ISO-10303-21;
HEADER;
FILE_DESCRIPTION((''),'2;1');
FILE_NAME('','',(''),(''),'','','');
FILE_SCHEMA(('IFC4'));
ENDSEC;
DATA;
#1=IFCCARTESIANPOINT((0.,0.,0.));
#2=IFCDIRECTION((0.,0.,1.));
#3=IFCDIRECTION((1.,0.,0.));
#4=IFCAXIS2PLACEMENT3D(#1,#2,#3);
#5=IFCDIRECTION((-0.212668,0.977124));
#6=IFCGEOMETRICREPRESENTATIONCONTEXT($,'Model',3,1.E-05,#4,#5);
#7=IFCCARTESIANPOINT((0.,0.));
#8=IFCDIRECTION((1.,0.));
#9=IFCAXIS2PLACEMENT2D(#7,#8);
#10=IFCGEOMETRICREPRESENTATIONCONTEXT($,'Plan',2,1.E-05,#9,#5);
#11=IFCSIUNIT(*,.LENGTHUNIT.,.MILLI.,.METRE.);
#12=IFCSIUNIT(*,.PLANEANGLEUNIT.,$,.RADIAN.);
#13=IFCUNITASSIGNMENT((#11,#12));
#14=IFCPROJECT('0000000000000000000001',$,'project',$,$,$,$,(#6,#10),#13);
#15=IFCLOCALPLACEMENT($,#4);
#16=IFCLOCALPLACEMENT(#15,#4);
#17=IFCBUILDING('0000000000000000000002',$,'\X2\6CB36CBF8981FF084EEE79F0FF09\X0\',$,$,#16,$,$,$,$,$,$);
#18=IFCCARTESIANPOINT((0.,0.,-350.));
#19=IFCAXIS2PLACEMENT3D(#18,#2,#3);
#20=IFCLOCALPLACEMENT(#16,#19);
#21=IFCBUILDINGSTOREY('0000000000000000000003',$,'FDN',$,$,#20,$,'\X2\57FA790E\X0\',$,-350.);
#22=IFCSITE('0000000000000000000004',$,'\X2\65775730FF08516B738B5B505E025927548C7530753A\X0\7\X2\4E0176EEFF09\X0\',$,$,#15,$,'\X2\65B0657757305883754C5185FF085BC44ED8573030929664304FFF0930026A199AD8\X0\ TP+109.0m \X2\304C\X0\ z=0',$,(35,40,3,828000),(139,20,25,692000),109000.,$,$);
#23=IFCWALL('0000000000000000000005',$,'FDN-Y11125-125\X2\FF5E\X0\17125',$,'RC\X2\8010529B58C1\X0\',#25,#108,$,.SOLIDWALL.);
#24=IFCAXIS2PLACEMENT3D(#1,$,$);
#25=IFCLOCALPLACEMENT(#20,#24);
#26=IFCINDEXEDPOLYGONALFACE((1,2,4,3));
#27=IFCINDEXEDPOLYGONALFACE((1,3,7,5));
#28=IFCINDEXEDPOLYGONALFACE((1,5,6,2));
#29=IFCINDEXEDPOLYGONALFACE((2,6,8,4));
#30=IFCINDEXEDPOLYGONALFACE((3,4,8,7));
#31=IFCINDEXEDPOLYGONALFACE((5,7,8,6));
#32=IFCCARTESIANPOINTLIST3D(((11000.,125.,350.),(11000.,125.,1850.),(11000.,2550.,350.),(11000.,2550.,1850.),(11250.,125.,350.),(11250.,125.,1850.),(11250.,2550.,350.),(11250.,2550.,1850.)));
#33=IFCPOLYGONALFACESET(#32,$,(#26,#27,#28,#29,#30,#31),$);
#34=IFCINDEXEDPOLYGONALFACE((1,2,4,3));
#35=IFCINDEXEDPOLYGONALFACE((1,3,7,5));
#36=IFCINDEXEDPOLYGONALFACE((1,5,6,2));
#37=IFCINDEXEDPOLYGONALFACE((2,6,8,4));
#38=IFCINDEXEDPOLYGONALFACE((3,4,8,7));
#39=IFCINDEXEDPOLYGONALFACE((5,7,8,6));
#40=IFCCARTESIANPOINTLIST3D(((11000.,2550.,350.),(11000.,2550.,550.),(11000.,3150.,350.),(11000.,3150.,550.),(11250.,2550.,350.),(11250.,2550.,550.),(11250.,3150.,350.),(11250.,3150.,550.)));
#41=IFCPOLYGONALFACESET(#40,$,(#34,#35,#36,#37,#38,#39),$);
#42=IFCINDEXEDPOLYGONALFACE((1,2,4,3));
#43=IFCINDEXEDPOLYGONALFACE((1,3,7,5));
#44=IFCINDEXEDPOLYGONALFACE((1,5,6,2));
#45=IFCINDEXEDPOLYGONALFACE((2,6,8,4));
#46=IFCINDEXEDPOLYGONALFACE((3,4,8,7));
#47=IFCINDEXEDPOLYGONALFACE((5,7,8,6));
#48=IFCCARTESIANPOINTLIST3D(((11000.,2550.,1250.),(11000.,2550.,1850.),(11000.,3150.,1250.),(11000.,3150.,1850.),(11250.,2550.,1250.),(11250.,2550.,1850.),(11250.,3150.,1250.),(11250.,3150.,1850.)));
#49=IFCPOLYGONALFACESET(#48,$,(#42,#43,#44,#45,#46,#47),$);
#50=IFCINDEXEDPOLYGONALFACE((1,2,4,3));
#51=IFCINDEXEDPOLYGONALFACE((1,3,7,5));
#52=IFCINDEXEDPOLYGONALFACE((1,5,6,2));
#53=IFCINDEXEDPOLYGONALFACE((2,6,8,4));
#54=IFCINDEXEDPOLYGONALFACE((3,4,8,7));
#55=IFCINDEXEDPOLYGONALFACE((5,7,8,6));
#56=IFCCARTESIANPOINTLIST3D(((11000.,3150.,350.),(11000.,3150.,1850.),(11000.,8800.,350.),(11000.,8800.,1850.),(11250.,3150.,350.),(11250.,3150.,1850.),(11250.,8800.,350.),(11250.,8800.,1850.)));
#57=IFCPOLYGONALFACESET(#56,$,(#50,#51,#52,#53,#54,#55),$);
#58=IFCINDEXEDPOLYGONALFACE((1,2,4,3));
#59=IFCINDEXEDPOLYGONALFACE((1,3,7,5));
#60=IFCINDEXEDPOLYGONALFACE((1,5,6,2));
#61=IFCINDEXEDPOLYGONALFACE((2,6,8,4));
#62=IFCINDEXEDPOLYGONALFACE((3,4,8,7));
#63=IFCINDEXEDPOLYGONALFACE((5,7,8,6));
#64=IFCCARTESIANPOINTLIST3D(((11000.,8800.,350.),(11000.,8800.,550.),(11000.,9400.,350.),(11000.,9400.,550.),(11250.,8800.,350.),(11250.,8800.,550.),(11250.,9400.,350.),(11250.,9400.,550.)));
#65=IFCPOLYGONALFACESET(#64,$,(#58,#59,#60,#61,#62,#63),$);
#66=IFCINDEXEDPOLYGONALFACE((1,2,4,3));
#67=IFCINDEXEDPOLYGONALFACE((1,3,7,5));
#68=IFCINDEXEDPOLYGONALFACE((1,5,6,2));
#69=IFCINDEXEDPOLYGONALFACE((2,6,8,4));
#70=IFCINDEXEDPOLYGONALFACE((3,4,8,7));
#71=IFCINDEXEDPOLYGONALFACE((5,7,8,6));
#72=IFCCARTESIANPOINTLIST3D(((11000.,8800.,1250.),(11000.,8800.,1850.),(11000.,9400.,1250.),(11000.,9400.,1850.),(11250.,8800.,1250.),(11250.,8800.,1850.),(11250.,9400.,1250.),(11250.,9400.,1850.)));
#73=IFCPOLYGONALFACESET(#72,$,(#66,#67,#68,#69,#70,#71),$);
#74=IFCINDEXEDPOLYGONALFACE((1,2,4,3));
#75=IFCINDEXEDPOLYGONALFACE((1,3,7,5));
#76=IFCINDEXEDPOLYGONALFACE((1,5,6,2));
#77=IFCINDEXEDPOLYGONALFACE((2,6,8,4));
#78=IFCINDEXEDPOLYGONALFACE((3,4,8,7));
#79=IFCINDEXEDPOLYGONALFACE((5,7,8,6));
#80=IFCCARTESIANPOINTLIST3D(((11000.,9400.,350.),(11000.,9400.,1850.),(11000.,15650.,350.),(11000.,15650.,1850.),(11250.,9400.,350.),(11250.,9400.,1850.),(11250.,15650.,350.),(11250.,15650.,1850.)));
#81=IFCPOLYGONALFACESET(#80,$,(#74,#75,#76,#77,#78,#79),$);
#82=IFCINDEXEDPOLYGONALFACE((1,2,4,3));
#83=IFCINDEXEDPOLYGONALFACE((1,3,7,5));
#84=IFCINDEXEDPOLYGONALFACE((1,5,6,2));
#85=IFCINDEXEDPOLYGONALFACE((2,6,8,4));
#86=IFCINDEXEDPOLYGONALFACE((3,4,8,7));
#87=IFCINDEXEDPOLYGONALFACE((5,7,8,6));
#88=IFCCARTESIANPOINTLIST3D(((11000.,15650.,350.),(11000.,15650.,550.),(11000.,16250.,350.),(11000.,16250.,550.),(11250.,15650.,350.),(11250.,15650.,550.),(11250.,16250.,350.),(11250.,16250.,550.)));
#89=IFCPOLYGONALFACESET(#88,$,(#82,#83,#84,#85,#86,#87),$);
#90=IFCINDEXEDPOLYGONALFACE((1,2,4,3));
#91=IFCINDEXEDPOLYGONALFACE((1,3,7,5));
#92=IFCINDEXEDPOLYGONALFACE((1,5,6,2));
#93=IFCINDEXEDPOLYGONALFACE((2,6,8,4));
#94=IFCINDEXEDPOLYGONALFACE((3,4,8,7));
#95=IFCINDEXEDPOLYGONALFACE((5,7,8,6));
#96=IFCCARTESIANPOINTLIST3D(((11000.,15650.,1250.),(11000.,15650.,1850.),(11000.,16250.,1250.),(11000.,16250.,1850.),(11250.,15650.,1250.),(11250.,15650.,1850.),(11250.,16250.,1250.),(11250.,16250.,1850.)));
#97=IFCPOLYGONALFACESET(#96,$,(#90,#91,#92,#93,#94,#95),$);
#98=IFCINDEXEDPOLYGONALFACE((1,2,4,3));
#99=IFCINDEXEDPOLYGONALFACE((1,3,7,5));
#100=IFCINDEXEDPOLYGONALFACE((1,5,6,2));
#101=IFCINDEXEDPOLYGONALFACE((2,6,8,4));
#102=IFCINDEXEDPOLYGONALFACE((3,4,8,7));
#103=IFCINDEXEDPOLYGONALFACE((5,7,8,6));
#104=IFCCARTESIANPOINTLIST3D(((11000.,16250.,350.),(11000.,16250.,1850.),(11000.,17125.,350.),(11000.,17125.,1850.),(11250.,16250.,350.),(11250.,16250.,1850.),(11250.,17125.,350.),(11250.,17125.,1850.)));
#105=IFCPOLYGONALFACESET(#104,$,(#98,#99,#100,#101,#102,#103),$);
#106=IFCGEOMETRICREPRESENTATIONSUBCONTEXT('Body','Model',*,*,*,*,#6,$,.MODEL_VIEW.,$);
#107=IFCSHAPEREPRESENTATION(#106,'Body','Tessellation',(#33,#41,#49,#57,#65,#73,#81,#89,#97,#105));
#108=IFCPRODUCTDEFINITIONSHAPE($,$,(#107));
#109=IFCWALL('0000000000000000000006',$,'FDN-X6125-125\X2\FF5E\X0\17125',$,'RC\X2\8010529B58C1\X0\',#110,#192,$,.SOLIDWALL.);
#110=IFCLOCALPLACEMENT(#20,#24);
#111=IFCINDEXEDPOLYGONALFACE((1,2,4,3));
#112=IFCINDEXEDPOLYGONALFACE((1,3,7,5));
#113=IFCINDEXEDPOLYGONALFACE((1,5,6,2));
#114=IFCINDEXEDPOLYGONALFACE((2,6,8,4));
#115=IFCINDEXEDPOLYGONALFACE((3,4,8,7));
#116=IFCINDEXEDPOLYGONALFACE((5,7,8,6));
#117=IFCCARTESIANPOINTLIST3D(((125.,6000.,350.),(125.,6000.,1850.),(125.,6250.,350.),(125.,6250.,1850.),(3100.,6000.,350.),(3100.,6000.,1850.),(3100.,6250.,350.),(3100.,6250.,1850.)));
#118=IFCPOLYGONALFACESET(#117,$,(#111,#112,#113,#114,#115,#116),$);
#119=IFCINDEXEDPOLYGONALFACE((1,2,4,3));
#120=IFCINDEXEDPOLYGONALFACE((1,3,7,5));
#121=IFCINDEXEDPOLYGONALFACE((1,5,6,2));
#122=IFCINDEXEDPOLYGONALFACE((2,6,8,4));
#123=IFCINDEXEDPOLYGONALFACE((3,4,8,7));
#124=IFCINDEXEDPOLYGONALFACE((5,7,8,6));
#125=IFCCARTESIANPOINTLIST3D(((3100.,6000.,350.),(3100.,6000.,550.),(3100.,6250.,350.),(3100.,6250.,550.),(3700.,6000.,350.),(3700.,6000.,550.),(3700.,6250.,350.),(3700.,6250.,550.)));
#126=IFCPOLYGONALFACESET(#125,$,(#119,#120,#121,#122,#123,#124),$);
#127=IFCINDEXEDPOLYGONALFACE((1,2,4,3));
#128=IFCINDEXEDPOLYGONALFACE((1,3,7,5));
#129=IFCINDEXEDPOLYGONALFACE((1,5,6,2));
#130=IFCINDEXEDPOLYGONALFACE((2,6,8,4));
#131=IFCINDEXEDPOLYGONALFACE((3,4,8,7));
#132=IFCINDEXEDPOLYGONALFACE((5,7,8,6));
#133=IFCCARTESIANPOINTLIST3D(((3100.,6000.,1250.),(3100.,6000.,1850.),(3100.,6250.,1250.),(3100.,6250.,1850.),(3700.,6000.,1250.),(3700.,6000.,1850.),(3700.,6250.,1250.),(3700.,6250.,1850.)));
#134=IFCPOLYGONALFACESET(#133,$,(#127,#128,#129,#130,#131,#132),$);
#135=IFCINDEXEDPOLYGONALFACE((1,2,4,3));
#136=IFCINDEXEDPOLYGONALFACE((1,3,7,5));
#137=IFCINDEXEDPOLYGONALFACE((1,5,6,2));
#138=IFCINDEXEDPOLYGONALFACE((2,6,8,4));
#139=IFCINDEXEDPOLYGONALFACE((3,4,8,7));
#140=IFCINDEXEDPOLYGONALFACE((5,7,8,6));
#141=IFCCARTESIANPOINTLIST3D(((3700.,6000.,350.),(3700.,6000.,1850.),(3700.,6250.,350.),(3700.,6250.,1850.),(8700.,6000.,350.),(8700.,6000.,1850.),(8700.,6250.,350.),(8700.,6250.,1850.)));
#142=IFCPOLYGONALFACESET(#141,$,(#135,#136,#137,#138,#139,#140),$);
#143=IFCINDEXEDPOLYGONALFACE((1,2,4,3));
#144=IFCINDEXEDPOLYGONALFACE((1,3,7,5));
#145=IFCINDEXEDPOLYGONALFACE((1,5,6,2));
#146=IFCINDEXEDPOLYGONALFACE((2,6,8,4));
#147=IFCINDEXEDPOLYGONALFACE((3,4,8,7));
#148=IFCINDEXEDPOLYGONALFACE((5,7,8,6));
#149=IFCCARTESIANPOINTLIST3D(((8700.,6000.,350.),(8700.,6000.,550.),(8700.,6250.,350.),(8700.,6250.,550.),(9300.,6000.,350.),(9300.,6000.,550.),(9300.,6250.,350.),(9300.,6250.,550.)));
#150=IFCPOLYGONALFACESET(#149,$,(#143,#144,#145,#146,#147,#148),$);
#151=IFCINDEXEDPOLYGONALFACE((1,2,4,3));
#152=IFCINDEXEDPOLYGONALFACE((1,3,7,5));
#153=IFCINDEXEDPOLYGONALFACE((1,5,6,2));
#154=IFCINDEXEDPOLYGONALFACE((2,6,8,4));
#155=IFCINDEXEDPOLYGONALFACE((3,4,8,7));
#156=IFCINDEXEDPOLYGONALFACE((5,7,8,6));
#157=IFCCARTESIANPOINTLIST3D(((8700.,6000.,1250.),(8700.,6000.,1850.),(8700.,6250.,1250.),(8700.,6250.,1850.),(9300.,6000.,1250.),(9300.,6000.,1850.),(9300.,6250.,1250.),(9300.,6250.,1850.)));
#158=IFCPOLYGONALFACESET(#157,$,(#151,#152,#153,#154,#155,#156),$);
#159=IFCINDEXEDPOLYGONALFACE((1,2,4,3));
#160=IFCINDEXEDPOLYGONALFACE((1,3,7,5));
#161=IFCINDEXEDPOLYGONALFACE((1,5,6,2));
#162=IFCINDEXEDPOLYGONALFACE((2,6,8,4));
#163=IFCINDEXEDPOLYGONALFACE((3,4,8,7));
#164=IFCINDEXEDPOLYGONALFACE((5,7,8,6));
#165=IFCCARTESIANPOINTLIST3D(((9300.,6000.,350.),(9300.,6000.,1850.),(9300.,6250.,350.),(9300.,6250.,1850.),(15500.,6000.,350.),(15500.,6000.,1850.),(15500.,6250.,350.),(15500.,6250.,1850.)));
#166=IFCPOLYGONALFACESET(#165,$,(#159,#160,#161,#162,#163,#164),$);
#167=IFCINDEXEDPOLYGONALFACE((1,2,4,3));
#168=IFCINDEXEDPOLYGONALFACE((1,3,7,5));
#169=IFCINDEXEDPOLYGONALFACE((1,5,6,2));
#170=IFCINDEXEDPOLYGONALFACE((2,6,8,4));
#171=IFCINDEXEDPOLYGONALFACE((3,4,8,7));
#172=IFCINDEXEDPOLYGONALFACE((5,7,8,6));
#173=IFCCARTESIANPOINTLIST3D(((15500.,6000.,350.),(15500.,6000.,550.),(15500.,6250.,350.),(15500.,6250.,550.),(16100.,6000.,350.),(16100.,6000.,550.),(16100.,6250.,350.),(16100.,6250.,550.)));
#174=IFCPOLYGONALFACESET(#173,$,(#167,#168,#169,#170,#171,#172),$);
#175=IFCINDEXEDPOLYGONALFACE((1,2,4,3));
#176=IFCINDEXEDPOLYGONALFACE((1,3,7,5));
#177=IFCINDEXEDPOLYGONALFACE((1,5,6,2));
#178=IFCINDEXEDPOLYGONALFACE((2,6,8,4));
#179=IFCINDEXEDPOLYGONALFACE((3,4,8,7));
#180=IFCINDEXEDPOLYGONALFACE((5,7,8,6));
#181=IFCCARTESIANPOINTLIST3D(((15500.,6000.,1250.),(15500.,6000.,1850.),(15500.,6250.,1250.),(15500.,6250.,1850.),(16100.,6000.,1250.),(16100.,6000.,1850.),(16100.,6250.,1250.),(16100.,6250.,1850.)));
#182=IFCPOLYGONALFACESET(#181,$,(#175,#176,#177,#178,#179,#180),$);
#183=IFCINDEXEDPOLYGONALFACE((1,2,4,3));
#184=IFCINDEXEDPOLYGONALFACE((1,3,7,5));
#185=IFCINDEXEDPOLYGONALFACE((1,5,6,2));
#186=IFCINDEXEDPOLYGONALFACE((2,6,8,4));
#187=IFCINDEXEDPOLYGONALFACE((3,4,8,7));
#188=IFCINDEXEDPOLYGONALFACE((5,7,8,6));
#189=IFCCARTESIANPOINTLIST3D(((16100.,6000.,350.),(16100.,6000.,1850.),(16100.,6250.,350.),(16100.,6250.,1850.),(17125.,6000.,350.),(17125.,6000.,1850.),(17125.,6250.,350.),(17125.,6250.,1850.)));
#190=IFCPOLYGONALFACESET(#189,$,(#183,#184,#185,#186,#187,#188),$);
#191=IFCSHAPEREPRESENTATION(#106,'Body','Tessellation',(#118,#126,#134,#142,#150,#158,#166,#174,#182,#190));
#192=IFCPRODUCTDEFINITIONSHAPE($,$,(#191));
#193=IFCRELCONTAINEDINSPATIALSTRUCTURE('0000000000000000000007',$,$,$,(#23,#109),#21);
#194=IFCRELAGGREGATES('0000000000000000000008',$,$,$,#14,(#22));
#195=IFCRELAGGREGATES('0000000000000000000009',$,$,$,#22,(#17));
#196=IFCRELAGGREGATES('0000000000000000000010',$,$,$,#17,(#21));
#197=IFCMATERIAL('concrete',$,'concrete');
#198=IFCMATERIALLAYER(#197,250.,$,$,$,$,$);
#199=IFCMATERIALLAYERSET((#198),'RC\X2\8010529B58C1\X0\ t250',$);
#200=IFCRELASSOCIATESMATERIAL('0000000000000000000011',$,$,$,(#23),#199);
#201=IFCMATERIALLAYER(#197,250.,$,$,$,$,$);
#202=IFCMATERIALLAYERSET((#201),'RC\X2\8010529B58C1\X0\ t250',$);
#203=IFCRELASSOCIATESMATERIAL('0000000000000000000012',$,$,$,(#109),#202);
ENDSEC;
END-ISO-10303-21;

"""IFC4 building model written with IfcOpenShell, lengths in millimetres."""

from ifc_helpers import new_model, si_unit, direction, frame, frame_2d, origin_with_axes, origin_2d_with_axis, place, context, subcontext, project, spatial, rectangle, extrude, material, layer, layer_set, layer_usage, element, save


model = new_model("IFC4")

# Units and contexts
model_context = context("Model", 3, precision=1e-05, world=origin_with_axes(), true_north=direction((-0.212668, 0.977124)))
plan_context = context("Plan", 2, precision=1e-05, world=origin_2d_with_axis(), true_north=direction((-0.212668, 0.977124)))
body_context = subcontext(model_context, "Body", "Model", "MODEL_VIEW")
ifc_project = project(units=[si_unit("LENGTHUNIT", "METRE", prefix="MILLI"), si_unit("PLANEANGLEUNIT", "RADIAN")], contexts=[model_context, plan_context])

# Site, building, storey
site_placement = place(None, origin_with_axes())
site = spatial("IfcSite", under=ifc_project, at=site_placement, Name="敷地（八王子市大和田町7丁目）", LongName="新敷地境界内（寄付地を除く）。標高 TP+109.0m が z=0", RefLatitude=(35, 40, 3, 828000), RefLongitude=(139, 20, 25, 692000), RefElevation=109000.0)
building_placement = place(site_placement, origin_with_axes())
building = spatial("IfcBuilding", under=site, at=building_placement, Name="河沿要（仮称）")
storey_placement = place(building_placement, frame((0.0, 0.0, -350.0), z_axis=(0.0, 0.0, 1.0), x_axis=(1.0, 0.0, 0.0)))
storey = spatial("IfcBuildingStorey", under=building, at=storey_placement, Name="FDN", LongName="基礎", Elevation=-350.0)

# Shared definitions
ifc_material_1 = material(Name="concrete", Category="concrete")

# Walls, openings
ifc_layer_1 = layer(ifc_material_1, 250.0)
ifc_layer_set_1 = layer_set([ifc_layer_1], Name="RC耐力壁 t250")
ifc_layer_usage_1 = layer_usage(ifc_layer_set_1, "AXIS2", "POSITIVE", 0.0)
wall_1_placement = place(storey_placement, origin_with_axes())
wall_1 = element("IfcWall", 1, at=wall_1_placement, inside=storey, material=ifc_layer_usage_1, Name="FDN-Y11125-125～17125", ObjectType="RC耐力壁", PredefinedType="SOLIDWALL", context=body_context, shape_type="SweptSolid", body=[
    extrude(rectangle(XDim=250.0, YDim=2425.0, at=frame_2d((11125.0, 1337.5))), frame((0.0, 0.0, 350.0)), (0.0, 0.0, 1.0), 1500.0),
    extrude(rectangle(XDim=250.0, YDim=600.0, at=frame_2d((11125.0, 2850.0))), frame((0.0, 0.0, 350.0)), (0.0, 0.0, 1.0), 200.0),
    extrude(rectangle(XDim=250.0, YDim=600.0, at=frame_2d((11125.0, 2850.0))), frame((0.0, 0.0, 1250.0)), (0.0, 0.0, 1.0), 600.0),
    extrude(rectangle(XDim=250.0, YDim=5650.0, at=frame_2d((11125.0, 5975.0))), frame((0.0, 0.0, 350.0)), (0.0, 0.0, 1.0), 1500.0),
    extrude(rectangle(XDim=250.0, YDim=600.0, at=frame_2d((11125.0, 9100.0))), frame((0.0, 0.0, 350.0)), (0.0, 0.0, 1.0), 200.0),
    extrude(rectangle(XDim=250.0, YDim=600.0, at=frame_2d((11125.0, 9100.0))), frame((0.0, 0.0, 1250.0)), (0.0, 0.0, 1.0), 600.0),
    extrude(rectangle(XDim=250.0, YDim=6250.0, at=frame_2d((11125.0, 12525.0))), frame((0.0, 0.0, 350.0)), (0.0, 0.0, 1.0), 1500.0),
    extrude(rectangle(XDim=250.0, YDim=600.0, at=frame_2d((11125.0, 15950.0))), frame((0.0, 0.0, 350.0)), (0.0, 0.0, 1.0), 200.0),
    extrude(rectangle(XDim=250.0, YDim=600.0, at=frame_2d((11125.0, 15950.0))), frame((0.0, 0.0, 1250.0)), (0.0, 0.0, 1.0), 600.0),
    extrude(rectangle(XDim=250.0, YDim=875.0, at=frame_2d((11125.0, 16687.5))), frame((0.0, 0.0, 350.0)), (0.0, 0.0, 1.0), 1500.0),
])
opening_1_placement = place(storey_placement, origin_with_axes())
element("IfcOpeningElement", 2, at=opening_1_placement, inside=storey, cuts=wall_1, PredefinedType="OPENING", context=body_context, shape_type="SweptSolid", body=[
    extrude(rectangle(XDim=300.0, YDim=600.0, at=frame_2d((11125.0, 2850.0))), frame((0.0, 0.0, 550.0)), (0.0, 0.0, 1.0), 700.0),
])
opening_2_placement = place(storey_placement, origin_with_axes())
element("IfcOpeningElement", 3, at=opening_2_placement, inside=storey, cuts=wall_1, PredefinedType="OPENING", context=body_context, shape_type="SweptSolid", body=[
    extrude(rectangle(XDim=300.0, YDim=600.0, at=frame_2d((11125.0, 9100.0))), frame((0.0, 0.0, 550.0)), (0.0, 0.0, 1.0), 700.0),
])
opening_3_placement = place(storey_placement, origin_with_axes())
element("IfcOpeningElement", 4, at=opening_3_placement, inside=storey, cuts=wall_1, PredefinedType="OPENING", context=body_context, shape_type="SweptSolid", body=[
    extrude(rectangle(XDim=300.0, YDim=600.0, at=frame_2d((11125.0, 15950.0))), frame((0.0, 0.0, 550.0)), (0.0, 0.0, 1.0), 700.0),
])
ifc_layer_2 = layer(ifc_material_1, 250.0)
ifc_layer_set_2 = layer_set([ifc_layer_2], Name="RC耐力壁 t250")
ifc_layer_usage_2 = layer_usage(ifc_layer_set_2, "AXIS2", "POSITIVE", 0.0)
wall_2_placement = place(storey_placement, origin_with_axes())
wall_2 = element("IfcWall", 5, at=wall_2_placement, inside=storey, material=ifc_layer_usage_2, Name="FDN-X6125-125～17125", ObjectType="RC耐力壁", PredefinedType="SOLIDWALL", context=body_context, shape_type="SweptSolid", body=[
    extrude(rectangle(XDim=2975.0, YDim=250.0, at=frame_2d((1612.5, 6125.0))), frame((0.0, 0.0, 350.0)), (0.0, 0.0, 1.0), 1500.0),
    extrude(rectangle(XDim=600.0, YDim=250.0, at=frame_2d((3400.0, 6125.0))), frame((0.0, 0.0, 350.0)), (0.0, 0.0, 1.0), 200.0),
    extrude(rectangle(XDim=600.0, YDim=250.0, at=frame_2d((3400.0, 6125.0))), frame((0.0, 0.0, 1250.0)), (0.0, 0.0, 1.0), 600.0),
    extrude(rectangle(XDim=5000.0, YDim=250.0, at=frame_2d((6200.0, 6125.0))), frame((0.0, 0.0, 350.0)), (0.0, 0.0, 1.0), 1500.0),
    extrude(rectangle(XDim=600.0, YDim=250.0, at=frame_2d((9000.0, 6125.0))), frame((0.0, 0.0, 350.0)), (0.0, 0.0, 1.0), 200.0),
    extrude(rectangle(XDim=600.0, YDim=250.0, at=frame_2d((9000.0, 6125.0))), frame((0.0, 0.0, 1250.0)), (0.0, 0.0, 1.0), 600.0),
    extrude(rectangle(XDim=6200.0, YDim=250.0, at=frame_2d((12400.0, 6125.0))), frame((0.0, 0.0, 350.0)), (0.0, 0.0, 1.0), 1500.0),
    extrude(rectangle(XDim=600.0, YDim=250.0, at=frame_2d((15800.0, 6125.0))), frame((0.0, 0.0, 350.0)), (0.0, 0.0, 1.0), 200.0),
    extrude(rectangle(XDim=600.0, YDim=250.0, at=frame_2d((15800.0, 6125.0))), frame((0.0, 0.0, 1250.0)), (0.0, 0.0, 1.0), 600.0),
    extrude(rectangle(XDim=1025.0, YDim=250.0, at=frame_2d((16612.5, 6125.0))), frame((0.0, 0.0, 350.0)), (0.0, 0.0, 1.0), 1500.0),
])
opening_4_placement = place(storey_placement, origin_with_axes())
element("IfcOpeningElement", 6, at=opening_4_placement, inside=storey, cuts=wall_2, PredefinedType="OPENING", context=body_context, shape_type="SweptSolid", body=[
    extrude(rectangle(XDim=600.0, YDim=300.0, at=frame_2d((3400.0, 6125.0))), frame((0.0, 0.0, 550.0)), (0.0, 0.0, 1.0), 700.0),
])
opening_5_placement = place(storey_placement, origin_with_axes())
element("IfcOpeningElement", 7, at=opening_5_placement, inside=storey, cuts=wall_2, PredefinedType="OPENING", context=body_context, shape_type="SweptSolid", body=[
    extrude(rectangle(XDim=600.0, YDim=300.0, at=frame_2d((9000.0, 6125.0))), frame((0.0, 0.0, 550.0)), (0.0, 0.0, 1.0), 700.0),
])
opening_6_placement = place(storey_placement, origin_with_axes())
element("IfcOpeningElement", 8, at=opening_6_placement, inside=storey, cuts=wall_2, PredefinedType="OPENING", context=body_context, shape_type="SweptSolid", body=[
    extrude(rectangle(XDim=600.0, YDim=300.0, at=frame_2d((15800.0, 6125.0))), frame((0.0, 0.0, 550.0)), (0.0, 0.0, 1.0), 700.0),
])

save(model, "model.ifc")
